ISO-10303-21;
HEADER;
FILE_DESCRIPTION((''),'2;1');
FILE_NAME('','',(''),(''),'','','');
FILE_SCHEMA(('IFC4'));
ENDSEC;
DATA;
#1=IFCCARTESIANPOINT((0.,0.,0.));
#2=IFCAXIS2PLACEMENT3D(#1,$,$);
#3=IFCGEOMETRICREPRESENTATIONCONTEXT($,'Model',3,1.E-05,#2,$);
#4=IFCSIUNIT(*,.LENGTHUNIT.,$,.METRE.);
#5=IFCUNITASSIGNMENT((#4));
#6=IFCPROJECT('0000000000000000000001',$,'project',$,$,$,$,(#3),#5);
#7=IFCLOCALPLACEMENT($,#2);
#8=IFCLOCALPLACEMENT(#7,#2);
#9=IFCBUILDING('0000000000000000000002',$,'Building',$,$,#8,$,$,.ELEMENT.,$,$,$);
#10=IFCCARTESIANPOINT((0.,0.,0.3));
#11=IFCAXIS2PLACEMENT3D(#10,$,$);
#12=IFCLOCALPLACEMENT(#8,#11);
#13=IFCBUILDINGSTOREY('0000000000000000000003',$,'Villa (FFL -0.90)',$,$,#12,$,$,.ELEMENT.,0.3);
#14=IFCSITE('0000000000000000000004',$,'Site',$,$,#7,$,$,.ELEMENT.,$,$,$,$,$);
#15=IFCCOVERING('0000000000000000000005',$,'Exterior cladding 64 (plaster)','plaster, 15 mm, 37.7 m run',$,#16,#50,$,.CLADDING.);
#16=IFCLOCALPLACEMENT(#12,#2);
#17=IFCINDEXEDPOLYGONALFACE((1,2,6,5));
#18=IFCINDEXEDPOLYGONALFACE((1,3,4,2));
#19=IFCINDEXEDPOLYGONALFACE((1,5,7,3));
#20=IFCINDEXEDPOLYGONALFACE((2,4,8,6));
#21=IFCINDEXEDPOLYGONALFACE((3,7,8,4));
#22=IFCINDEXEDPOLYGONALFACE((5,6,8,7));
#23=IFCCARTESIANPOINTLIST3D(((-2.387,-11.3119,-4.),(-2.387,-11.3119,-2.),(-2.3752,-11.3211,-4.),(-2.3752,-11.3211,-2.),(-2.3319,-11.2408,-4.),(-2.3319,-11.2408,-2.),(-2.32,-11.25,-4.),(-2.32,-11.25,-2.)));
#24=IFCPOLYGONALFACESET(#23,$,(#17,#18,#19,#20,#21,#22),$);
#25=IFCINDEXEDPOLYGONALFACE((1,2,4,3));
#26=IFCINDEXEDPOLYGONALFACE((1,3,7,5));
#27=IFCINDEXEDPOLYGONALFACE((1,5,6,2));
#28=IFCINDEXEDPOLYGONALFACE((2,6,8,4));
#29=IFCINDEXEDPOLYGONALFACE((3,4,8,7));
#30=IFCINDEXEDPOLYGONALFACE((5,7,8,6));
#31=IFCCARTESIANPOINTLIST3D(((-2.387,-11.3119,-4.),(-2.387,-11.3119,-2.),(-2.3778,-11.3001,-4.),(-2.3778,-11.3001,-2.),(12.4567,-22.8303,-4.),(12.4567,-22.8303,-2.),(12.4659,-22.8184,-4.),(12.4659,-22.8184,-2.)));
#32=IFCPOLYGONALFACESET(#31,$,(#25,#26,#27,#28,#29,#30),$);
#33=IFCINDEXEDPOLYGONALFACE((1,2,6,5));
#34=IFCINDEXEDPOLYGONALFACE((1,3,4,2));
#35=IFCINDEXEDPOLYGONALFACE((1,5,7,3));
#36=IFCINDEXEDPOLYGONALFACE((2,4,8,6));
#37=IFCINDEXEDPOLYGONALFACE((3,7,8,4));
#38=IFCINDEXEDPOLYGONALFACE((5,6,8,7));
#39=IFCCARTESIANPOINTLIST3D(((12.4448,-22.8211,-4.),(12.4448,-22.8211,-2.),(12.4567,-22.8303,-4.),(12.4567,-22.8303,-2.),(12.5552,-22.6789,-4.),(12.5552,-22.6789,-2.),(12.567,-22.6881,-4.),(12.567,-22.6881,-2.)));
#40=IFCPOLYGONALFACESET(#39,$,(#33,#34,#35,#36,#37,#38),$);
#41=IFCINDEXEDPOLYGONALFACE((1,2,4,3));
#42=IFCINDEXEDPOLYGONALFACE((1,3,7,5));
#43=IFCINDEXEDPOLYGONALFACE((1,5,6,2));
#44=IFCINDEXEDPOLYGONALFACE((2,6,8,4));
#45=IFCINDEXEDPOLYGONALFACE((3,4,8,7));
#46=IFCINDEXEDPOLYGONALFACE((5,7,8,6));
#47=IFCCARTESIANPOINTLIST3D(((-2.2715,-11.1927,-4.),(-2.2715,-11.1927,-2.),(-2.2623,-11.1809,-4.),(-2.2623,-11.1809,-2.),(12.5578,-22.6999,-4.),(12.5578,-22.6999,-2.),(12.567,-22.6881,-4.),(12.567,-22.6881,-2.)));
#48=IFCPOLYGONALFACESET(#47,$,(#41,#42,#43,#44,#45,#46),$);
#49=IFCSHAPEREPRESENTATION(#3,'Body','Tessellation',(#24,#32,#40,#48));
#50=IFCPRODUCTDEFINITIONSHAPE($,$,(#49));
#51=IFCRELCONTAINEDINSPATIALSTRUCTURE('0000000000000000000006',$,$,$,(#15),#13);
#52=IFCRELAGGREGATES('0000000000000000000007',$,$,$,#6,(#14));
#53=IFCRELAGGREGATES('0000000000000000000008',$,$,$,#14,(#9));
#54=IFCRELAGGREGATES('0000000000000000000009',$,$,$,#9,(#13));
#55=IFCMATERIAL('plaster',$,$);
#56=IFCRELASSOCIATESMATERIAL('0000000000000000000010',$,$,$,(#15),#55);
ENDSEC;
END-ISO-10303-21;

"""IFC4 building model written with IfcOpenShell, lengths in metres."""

from ifc_helpers import new_model, si_unit, frame, origin, origin_with_axes, place, context, project, spatial, polyline, outline, extrude, material, element, save


model = new_model("IFC4")

# Units and contexts
model_context = context("Model", 3, precision=1e-05, world=origin())
ifc_project = project(units=[si_unit("LENGTHUNIT", "METRE")], contexts=[model_context])

# Site, building, storey
site_placement = place(None, origin())
site = spatial("IfcSite", under=ifc_project, at=site_placement, Name="Site", CompositionType="ELEMENT")
building_placement = place(site_placement, origin())
building = spatial("IfcBuilding", under=site, at=building_placement, Name="Building", CompositionType="ELEMENT")
storey_placement = place(building_placement, frame((0.0, 0.0, 0.3)))
storey = spatial("IfcBuildingStorey", under=building, at=storey_placement, Name="Villa (FFL -0.90)", CompositionType="ELEMENT", Elevation=0.3)

# Covering
ifc_material = material(Name="plaster")
covering_1_placement = place(storey_placement, origin_with_axes())
element("IfcCovering", 1, at=covering_1_placement, inside=storey, material=ifc_material, Name="Exterior cladding 64 (plaster)", Description="plaster, 15 mm, 37.7 m run", PredefinedType="CLADDING", context=model_context, shape_type="SweptSolid", body=[
    extrude(outline(polyline([(-2.3319, -11.2408), (-2.387, -11.3119), (-2.3752, -11.3211), (-2.32, -11.25), (-2.3319, -11.2408)])), frame((0.0, 0.0, -4.0)), (0.0, 0.0, 1.0), 2.0),
    extrude(outline(polyline([(-2.387, -11.3119), (12.4567, -22.8303), (12.4659, -22.8184), (-2.3778, -11.3001), (-2.387, -11.3119)])), frame((0.0, 0.0, -4.0)), (0.0, 0.0, 1.0), 2.0),
    extrude(outline(polyline([(12.4567, -22.8303), (12.567, -22.6881), (12.5552, -22.6789), (12.4448, -22.8211), (12.4567, -22.8303)])), frame((0.0, 0.0, -4.0)), (0.0, 0.0, 1.0), 2.0),
    extrude(outline(polyline([(12.567, -22.6881), (-2.2623, -11.1809), (-2.2715, -11.1927), (12.5578, -22.6999), (12.567, -22.6881)])), frame((0.0, 0.0, -4.0)), (0.0, 0.0, 1.0), 2.0),
])

save(model, "model.ifc")
